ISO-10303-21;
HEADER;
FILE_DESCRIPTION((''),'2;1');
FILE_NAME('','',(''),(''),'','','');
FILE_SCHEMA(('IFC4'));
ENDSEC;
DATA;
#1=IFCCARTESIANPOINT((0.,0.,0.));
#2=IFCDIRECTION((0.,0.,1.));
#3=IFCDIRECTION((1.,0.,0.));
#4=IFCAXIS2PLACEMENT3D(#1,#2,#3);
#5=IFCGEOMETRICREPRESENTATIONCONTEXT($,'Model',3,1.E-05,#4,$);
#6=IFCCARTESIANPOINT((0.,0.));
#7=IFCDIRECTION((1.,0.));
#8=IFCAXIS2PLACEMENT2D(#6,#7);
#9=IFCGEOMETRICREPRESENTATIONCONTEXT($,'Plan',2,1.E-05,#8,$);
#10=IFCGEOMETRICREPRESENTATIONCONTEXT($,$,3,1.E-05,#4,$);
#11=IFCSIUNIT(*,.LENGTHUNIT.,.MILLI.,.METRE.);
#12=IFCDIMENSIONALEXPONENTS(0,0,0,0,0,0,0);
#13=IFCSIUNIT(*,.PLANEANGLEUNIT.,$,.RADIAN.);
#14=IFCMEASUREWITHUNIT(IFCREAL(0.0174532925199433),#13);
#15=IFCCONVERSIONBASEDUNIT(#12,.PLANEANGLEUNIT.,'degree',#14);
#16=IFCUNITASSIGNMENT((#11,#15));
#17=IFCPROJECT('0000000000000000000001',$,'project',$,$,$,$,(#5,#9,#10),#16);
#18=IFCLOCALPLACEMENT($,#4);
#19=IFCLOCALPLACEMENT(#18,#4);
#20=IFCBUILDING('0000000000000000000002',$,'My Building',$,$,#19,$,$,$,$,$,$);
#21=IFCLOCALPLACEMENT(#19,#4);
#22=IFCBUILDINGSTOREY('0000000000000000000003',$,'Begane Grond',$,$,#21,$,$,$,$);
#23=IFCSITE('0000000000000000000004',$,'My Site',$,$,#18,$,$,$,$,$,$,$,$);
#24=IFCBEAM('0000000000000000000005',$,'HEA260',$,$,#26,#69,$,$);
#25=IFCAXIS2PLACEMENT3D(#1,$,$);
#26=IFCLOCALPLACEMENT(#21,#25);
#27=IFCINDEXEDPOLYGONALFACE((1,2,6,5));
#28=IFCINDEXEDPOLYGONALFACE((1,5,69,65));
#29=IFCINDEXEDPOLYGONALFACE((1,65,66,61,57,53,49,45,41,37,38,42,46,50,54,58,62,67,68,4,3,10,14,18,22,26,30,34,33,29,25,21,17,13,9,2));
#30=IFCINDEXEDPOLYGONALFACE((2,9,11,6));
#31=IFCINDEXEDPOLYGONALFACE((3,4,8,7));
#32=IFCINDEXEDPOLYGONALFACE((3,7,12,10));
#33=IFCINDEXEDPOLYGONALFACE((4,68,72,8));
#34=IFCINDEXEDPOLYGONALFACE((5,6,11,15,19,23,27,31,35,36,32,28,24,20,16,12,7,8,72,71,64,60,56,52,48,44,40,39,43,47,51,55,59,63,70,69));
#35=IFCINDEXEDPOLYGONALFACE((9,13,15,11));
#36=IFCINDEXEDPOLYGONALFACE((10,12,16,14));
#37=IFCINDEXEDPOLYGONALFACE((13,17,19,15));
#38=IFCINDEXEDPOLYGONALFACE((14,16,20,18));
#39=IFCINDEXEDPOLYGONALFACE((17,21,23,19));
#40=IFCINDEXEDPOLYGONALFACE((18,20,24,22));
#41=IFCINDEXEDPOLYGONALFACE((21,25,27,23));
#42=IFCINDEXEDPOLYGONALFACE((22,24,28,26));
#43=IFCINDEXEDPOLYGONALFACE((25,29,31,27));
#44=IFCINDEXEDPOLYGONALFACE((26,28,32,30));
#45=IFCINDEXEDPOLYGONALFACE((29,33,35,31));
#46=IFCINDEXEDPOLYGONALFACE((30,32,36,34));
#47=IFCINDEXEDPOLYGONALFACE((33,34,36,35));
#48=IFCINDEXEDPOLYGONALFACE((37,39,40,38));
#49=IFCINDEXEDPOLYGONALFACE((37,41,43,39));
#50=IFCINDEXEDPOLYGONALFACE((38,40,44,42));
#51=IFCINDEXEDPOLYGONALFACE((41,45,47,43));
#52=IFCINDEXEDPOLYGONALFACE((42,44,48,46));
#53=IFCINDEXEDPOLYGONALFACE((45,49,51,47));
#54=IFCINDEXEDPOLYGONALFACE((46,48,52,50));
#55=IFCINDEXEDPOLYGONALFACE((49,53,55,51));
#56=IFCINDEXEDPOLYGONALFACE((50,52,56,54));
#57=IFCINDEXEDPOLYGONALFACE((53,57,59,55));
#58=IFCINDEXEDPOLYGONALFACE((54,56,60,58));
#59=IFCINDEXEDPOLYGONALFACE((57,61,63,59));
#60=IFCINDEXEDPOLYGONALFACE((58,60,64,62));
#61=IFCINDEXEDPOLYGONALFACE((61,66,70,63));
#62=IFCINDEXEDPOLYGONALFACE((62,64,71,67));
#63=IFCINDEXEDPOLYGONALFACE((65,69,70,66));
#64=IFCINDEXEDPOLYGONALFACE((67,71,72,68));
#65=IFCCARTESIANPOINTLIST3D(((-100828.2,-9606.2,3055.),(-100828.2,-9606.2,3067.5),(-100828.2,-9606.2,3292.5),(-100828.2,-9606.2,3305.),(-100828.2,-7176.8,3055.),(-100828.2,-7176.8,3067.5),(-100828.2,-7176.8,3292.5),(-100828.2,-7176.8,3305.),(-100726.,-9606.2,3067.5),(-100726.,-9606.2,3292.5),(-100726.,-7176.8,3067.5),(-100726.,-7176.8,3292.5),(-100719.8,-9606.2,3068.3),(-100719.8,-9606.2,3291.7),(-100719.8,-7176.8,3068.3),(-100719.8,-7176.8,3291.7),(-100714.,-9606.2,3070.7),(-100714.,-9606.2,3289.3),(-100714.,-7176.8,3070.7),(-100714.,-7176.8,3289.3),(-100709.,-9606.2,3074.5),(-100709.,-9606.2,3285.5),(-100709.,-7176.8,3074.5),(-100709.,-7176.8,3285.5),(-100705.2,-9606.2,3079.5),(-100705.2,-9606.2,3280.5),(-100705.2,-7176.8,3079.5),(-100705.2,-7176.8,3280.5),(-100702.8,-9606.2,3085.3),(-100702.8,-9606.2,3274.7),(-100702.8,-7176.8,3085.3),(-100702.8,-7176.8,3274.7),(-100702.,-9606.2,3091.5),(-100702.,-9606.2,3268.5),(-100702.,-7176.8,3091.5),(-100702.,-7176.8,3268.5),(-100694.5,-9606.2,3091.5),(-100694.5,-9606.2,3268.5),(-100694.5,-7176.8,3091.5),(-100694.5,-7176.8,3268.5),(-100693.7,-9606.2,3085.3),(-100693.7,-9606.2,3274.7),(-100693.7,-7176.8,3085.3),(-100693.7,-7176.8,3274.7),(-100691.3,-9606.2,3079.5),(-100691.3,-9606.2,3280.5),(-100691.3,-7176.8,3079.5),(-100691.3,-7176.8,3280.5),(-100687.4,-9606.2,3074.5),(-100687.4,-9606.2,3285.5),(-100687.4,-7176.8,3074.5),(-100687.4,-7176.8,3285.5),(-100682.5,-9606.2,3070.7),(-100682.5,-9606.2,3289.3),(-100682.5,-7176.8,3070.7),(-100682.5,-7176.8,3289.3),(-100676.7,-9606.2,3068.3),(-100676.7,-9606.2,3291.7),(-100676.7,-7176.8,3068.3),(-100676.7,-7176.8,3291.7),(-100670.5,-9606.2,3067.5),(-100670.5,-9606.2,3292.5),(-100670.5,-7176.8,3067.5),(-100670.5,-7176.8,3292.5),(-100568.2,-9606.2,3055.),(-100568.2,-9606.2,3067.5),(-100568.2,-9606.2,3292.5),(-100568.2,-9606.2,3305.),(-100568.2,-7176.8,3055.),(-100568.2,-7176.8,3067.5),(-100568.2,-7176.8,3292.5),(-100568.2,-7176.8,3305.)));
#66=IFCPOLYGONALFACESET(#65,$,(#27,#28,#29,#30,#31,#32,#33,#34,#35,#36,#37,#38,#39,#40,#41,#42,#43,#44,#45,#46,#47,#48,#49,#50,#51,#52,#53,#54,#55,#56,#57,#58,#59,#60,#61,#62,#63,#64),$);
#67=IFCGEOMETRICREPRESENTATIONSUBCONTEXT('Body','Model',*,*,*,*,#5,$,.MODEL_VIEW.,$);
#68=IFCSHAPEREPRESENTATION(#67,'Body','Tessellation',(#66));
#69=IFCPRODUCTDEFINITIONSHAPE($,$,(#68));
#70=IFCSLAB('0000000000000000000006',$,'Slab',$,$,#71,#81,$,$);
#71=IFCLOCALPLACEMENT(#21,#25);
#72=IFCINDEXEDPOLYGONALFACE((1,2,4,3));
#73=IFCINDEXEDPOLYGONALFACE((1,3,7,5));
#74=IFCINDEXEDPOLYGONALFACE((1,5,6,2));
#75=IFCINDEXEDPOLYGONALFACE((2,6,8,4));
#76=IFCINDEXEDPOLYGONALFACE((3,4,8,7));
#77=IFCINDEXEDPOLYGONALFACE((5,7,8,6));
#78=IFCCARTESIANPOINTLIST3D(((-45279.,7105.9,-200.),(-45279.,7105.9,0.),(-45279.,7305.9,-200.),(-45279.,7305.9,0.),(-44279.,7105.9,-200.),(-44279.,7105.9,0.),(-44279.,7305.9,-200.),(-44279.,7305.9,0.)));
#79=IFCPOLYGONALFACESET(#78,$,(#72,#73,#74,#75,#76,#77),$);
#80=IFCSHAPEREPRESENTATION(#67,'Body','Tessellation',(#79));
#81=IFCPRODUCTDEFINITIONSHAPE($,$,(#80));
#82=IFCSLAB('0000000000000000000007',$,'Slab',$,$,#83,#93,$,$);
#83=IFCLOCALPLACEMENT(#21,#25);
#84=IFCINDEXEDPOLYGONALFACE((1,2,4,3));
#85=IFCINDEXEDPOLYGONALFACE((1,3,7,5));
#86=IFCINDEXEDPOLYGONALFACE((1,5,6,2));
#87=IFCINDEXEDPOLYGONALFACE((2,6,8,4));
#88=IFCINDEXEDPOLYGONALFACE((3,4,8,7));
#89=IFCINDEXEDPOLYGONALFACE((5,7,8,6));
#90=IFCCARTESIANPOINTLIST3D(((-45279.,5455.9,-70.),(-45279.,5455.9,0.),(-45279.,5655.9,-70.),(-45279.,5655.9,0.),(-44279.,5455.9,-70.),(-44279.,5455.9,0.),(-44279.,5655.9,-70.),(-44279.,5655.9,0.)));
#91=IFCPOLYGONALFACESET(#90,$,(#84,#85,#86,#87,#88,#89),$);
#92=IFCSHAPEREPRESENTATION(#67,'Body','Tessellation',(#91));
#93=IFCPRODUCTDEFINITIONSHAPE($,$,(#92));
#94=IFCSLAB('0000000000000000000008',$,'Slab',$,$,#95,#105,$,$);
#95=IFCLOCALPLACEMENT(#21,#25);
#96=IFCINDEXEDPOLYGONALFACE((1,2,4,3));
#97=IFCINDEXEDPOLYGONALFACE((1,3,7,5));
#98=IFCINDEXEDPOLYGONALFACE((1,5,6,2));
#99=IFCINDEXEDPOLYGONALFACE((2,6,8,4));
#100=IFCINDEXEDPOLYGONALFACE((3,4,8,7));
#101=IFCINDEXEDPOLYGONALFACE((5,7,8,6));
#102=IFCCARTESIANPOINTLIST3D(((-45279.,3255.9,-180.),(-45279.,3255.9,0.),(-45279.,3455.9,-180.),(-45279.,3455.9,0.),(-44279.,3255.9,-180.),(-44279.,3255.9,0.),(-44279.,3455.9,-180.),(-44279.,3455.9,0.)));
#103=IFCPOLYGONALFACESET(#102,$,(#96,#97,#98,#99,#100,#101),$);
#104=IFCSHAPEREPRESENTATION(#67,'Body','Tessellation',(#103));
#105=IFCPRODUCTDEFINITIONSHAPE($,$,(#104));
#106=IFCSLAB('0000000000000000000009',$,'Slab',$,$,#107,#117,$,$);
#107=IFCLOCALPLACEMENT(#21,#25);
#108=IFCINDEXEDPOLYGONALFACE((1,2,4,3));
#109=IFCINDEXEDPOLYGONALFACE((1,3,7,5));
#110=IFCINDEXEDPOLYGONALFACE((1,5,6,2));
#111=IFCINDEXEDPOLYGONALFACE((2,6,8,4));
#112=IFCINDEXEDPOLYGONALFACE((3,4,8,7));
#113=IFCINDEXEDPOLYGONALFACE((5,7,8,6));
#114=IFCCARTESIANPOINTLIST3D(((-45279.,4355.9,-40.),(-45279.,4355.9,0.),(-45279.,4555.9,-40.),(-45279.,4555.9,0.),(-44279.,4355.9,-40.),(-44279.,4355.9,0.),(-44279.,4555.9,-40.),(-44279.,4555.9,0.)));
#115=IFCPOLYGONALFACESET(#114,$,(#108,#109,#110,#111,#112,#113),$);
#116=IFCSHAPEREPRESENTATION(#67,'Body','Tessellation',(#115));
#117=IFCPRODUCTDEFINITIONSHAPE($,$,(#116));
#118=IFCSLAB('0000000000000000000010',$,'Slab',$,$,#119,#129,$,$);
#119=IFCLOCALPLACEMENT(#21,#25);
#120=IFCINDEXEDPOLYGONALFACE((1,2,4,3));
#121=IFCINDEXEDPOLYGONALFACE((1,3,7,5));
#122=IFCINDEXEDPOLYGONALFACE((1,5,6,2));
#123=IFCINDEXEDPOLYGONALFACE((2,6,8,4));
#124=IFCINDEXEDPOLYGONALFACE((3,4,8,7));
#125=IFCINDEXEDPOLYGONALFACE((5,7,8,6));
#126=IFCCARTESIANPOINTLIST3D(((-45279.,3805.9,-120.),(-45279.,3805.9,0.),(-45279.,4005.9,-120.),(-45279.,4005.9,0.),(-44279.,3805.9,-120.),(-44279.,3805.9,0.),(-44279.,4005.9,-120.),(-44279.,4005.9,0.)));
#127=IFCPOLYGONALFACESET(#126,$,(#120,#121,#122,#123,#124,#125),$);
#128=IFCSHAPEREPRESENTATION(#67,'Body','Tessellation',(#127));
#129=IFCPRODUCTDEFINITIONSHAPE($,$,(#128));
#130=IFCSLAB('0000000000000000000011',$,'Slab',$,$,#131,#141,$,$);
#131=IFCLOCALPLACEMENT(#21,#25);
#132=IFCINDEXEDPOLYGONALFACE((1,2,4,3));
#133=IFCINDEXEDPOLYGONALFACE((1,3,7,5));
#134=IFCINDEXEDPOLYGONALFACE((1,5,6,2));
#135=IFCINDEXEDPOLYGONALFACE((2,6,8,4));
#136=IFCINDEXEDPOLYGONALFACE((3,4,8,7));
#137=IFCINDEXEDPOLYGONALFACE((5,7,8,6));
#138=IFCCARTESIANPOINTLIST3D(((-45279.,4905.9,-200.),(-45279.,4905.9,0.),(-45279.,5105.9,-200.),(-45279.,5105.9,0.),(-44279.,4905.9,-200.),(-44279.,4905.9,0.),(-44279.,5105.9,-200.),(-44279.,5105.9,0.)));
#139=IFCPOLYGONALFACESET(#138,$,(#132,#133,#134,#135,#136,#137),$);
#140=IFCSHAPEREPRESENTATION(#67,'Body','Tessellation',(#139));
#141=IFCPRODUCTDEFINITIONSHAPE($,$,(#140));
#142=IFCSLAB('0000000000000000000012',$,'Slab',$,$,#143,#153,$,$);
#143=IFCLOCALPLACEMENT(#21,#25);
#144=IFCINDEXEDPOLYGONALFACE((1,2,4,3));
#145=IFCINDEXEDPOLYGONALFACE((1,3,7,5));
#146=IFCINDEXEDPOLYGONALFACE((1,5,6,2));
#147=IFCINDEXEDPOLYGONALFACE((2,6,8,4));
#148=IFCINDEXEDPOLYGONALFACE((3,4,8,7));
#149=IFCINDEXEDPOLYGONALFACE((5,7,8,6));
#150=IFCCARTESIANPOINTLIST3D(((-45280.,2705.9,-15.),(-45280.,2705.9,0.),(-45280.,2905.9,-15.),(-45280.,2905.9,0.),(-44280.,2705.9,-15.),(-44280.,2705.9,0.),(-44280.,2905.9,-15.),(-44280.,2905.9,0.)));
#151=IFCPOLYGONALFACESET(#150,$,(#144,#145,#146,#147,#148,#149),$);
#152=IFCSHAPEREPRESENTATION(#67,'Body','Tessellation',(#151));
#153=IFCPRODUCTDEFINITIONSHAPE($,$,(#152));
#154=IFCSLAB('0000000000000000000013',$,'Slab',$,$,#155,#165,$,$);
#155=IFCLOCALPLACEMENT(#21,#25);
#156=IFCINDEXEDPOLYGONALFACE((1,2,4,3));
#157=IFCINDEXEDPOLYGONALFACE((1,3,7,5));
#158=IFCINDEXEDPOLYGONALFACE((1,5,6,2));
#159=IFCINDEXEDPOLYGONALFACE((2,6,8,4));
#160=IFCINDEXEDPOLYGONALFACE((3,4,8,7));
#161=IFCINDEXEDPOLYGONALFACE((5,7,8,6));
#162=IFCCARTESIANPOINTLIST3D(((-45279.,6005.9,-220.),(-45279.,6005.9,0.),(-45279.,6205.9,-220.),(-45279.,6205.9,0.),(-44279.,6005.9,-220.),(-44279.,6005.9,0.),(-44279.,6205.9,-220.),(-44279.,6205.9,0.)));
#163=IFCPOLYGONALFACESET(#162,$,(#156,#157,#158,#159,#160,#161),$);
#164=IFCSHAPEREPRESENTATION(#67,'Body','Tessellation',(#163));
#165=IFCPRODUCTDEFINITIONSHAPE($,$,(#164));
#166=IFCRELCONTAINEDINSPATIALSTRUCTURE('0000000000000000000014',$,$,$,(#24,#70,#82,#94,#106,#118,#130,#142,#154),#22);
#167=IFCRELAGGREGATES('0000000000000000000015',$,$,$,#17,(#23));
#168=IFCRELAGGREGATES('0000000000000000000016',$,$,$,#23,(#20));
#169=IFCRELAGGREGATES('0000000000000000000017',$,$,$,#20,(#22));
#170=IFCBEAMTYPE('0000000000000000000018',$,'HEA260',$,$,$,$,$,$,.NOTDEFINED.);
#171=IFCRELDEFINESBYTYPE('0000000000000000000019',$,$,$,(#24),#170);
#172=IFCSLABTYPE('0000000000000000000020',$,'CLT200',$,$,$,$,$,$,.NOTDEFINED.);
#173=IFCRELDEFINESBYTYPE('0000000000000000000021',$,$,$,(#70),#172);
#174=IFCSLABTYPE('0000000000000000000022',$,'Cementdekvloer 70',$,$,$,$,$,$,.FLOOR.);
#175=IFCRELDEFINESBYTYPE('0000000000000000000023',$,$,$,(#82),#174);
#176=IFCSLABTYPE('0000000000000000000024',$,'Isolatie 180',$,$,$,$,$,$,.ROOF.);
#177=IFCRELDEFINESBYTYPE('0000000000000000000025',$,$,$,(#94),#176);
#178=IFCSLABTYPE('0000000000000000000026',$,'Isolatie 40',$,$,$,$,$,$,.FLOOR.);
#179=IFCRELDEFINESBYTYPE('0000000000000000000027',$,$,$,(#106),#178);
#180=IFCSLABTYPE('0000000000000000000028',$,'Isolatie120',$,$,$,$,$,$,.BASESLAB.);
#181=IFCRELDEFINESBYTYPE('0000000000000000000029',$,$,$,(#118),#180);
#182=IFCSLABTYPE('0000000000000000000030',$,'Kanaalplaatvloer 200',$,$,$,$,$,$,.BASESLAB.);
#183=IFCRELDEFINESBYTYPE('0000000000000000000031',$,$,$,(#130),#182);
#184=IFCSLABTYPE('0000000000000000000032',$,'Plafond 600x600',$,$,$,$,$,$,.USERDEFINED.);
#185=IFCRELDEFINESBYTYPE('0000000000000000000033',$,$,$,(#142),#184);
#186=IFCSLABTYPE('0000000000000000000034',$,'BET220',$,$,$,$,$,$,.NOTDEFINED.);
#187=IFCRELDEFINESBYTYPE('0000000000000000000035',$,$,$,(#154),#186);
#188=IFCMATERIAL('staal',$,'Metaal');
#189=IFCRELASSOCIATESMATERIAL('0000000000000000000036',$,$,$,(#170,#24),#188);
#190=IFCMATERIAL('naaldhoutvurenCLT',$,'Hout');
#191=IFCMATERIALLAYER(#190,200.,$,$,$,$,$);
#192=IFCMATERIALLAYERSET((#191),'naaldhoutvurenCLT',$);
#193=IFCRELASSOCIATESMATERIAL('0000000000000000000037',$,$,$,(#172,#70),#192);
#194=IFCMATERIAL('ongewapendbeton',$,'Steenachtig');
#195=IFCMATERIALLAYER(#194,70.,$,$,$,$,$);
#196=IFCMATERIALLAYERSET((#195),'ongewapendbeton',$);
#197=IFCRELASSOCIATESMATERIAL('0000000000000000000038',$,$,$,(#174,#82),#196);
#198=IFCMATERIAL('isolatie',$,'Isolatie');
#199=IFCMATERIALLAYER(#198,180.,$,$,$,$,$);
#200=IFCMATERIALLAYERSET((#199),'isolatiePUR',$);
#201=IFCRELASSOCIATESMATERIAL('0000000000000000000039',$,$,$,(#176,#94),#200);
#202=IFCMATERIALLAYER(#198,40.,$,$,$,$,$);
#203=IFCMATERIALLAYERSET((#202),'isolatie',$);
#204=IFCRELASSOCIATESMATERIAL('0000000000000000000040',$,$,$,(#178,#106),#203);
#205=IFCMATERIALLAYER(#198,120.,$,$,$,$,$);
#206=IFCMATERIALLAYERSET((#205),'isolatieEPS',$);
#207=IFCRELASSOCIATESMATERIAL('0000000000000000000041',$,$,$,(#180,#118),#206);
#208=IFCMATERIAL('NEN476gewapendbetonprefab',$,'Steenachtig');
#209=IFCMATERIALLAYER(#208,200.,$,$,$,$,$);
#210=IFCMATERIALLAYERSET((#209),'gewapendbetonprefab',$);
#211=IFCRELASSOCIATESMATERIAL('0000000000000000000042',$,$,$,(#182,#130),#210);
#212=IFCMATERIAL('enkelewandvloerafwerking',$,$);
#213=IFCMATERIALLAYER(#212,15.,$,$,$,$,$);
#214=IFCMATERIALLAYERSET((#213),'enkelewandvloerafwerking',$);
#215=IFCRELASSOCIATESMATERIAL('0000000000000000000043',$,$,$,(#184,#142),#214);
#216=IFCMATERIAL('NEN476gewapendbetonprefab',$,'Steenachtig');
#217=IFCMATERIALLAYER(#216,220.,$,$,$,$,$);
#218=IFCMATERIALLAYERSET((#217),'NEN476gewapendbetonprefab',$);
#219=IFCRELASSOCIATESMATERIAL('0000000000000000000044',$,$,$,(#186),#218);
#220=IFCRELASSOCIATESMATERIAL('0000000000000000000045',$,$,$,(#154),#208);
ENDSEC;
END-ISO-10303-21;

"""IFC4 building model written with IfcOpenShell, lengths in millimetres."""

from ifc_helpers import new_model, entity, si_unit, converted_unit, frame, origin_with_axes, origin_2d_with_axis, place, context, subcontext, project, spatial, line, indexed_curve, i_section, outline, extrude, material, layer, layer_set, layer_usage, material_profile, profile_set, profile_usage, type_object, element, save


model = new_model("IFC4")

# Units and contexts
model_context = context("Model", 3, precision=1e-05, world=origin_with_axes())
plan_context = context("Plan", 2, precision=1e-05, world=origin_2d_with_axis())
context_of_model = context(None, 3, precision=1e-05, world=origin_with_axes())
body_context = subcontext(model_context, "Body", "Model", "MODEL_VIEW")
ifc_project = project(units=[si_unit("LENGTHUNIT", "METRE", prefix="MILLI"), converted_unit("PLANEANGLEUNIT", "degree", entity("IfcReal", 0.0174532925199433), si_unit("PLANEANGLEUNIT", "RADIAN"), dimensions=[0, 0, 0, 0, 0, 0, 0])], contexts=[model_context, plan_context, context_of_model])

# Site, building, storey
site_placement = place(None, frame((0.0, 0.0, 0.0), z_axis=(0.0, 0.0, 1.0), x_axis=(1.0, 0.0, 0.0)))
site = spatial("IfcSite", under=ifc_project, at=site_placement, Name="My Site")
building_placement = place(site_placement, origin_with_axes())
building = spatial("IfcBuilding", under=site, at=building_placement, Name="My Building")
storey_placement = place(building_placement, origin_with_axes())
storey = spatial("IfcBuildingStorey", under=building, at=storey_placement, Name="Begane Grond")

# Beam
ifc_material_1 = material(Name="staal", Category="Metaal")
ifc_material_profile = material_profile(ifc_material_1, i_section(OverallWidth=260.0, OverallDepth=250.0, WebThickness=7.5, FlangeThickness=12.5, FilletRadius=24.0))
ifc_profile_set = profile_set([ifc_material_profile], Name="HEA260")
ifc_profile_usage = profile_usage(ifc_profile_set, cardinal=5)
beam_type = type_object("IfcBeamType", Name="HEA260", PredefinedType="NOTDEFINED", material=ifc_profile_set)
beam_placement = place(storey_placement, frame((-100698.2, -9606.2, 3180.0), z_axis=(0.0, 1.0, 0.0), x_axis=(-1.0, 0.0, 0.0)))
element("IfcBeam", 1, at=beam_placement, inside=storey, type_object=beam_type, material=ifc_profile_usage, Name="HEA260", context=body_context, shape_type="SweptSolid", body=[
    extrude(i_section(OverallWidth=260.0, OverallDepth=250.0, WebThickness=7.5, FlangeThickness=12.5, FilletRadius=24.0), origin_with_axes(), (0.0, 0.0, 1.0), 2429.4),
])

# Slabs
ifc_material_2 = material(Name="naaldhoutvurenCLT", Category="Hout")
ifc_layer_1 = layer(ifc_material_2, 200.0)
ifc_layer_set_1 = layer_set([ifc_layer_1], Name="naaldhoutvurenCLT")
ifc_layer_usage_1 = layer_usage(ifc_layer_set_1, "AXIS3", "POSITIVE", 0.0)
slab_type_1 = type_object("IfcSlabType", Name="CLT200", PredefinedType="NOTDEFINED", material=ifc_layer_set_1)
slab_1_placement = place(storey_placement, frame((-45279.0, 7105.9, -200.0), z_axis=(0.0, 0.0, 1.0), x_axis=(1.0, 0.0, 0.0)))
element("IfcSlab", 2, at=slab_1_placement, inside=storey, type_object=slab_type_1, material=ifc_layer_usage_1, Name="Slab", context=body_context, shape_type="SweptSolid", body=[
    extrude(outline(indexed_curve([(1000.0, 200.0), (1000.0, 0.0), (0.0, 0.0), (0.0, 200.0)], segments=[line(3, 2), line(2, 1), line(1, 4), line(4, 3)], self_intersect=False)), None, (0.0, 0.0, 1.0), 200.0),
])
ifc_material_3 = material(Name="ongewapendbeton", Category="Steenachtig")
ifc_layer_2 = layer(ifc_material_3, 70.0)
ifc_layer_set_2 = layer_set([ifc_layer_2], Name="ongewapendbeton")
ifc_layer_usage_2 = layer_usage(ifc_layer_set_2, "AXIS3", "POSITIVE", 0.0)
slab_type_2 = type_object("IfcSlabType", Name="Cementdekvloer 70", PredefinedType="FLOOR", material=ifc_layer_set_2)
slab_2_placement = place(storey_placement, frame((-45279.0, 5455.9, -70.0), z_axis=(0.0, 0.0, 1.0), x_axis=(1.0, 0.0, 0.0)))
element("IfcSlab", 3, at=slab_2_placement, inside=storey, type_object=slab_type_2, material=ifc_layer_usage_2, Name="Slab", context=body_context, shape_type="SweptSolid", body=[
    extrude(outline(indexed_curve([(1000.0, 200.0), (1000.0, 0.0), (0.0, 0.0), (0.0, 200.0)], segments=[line(4, 1), line(1, 2), line(2, 3), line(3, 4)], self_intersect=False)), None, (0.0, 0.0, 1.0), 70.0),
])
ifc_material_4 = material(Name="isolatie", Category="Isolatie")
ifc_layer_3 = layer(ifc_material_4, 180.0)
ifc_layer_set_3 = layer_set([ifc_layer_3], Name="isolatiePUR")
ifc_layer_usage_3 = layer_usage(ifc_layer_set_3, "AXIS3", "POSITIVE", 0.0)
slab_type_3 = type_object("IfcSlabType", Name="Isolatie 180", PredefinedType="ROOF", material=ifc_layer_set_3)
slab_3_placement = place(storey_placement, frame((-45279.0, 3255.9, -180.0), z_axis=(0.0, 0.0, 1.0), x_axis=(1.0, 0.0, 0.0)))
element("IfcSlab", 4, at=slab_3_placement, inside=storey, type_object=slab_type_3, material=ifc_layer_usage_3, Name="Slab", context=body_context, shape_type="SweptSolid", body=[
    extrude(outline(indexed_curve([(1000.0, 200.0), (1000.0, 0.0), (0.0, 0.0), (0.0, 200.0)], segments=[line(4, 1), line(1, 2), line(2, 3), line(3, 4)], self_intersect=False)), None, (0.0, 0.0, 1.0), 180.0),
])
ifc_layer_4 = layer(ifc_material_4, 40.0)
ifc_layer_set_4 = layer_set([ifc_layer_4], Name="isolatie")
ifc_layer_usage_4 = layer_usage(ifc_layer_set_4, "AXIS3", "POSITIVE", 0.0)
slab_type_4 = type_object("IfcSlabType", Name="Isolatie 40", PredefinedType="FLOOR", material=ifc_layer_set_4)
slab_4_placement = place(storey_placement, frame((-45279.0, 4355.9, -40.0), z_axis=(0.0, 0.0, 1.0), x_axis=(1.0, 0.0, 0.0)))
element("IfcSlab", 5, at=slab_4_placement, inside=storey, type_object=slab_type_4, material=ifc_layer_usage_4, Name="Slab", context=body_context, shape_type="SweptSolid", body=[
    extrude(outline(indexed_curve([(1000.0, 200.0), (1000.0, 0.0), (0.0, 0.0), (0.0, 200.0)], segments=[line(3, 2), line(2, 1), line(1, 4), line(4, 3)], self_intersect=False)), None, (0.0, 0.0, 1.0), 40.0),
])
ifc_layer_5 = layer(ifc_material_4, 120.0)
ifc_layer_set_5 = layer_set([ifc_layer_5], Name="isolatieEPS")
ifc_layer_usage_5 = layer_usage(ifc_layer_set_5, "AXIS3", "POSITIVE", 0.0)
slab_type_5 = type_object("IfcSlabType", Name="Isolatie120", PredefinedType="BASESLAB", material=ifc_layer_set_5)
slab_5_placement = place(storey_placement, frame((-45279.0, 3805.9, -120.0), z_axis=(0.0, 0.0, 1.0), x_axis=(1.0, 0.0, 0.0)))
element("IfcSlab", 6, at=slab_5_placement, inside=storey, type_object=slab_type_5, material=ifc_layer_usage_5, Name="Slab", context=body_context, shape_type="SweptSolid", body=[
    extrude(outline(indexed_curve([(1000.0, 200.0), (1000.0, 0.0), (0.0, 0.0), (0.0, 200.0)], segments=[line(3, 2), line(2, 1), line(1, 4), line(4, 3)], self_intersect=False)), None, (0.0, 0.0, 1.0), 120.0),
])
ifc_material_5 = material(Name="NEN476gewapendbetonprefab", Category="Steenachtig")
ifc_layer_6 = layer(ifc_material_5, 200.0)
ifc_layer_set_6 = layer_set([ifc_layer_6], Name="gewapendbetonprefab")
ifc_layer_usage_6 = layer_usage(ifc_layer_set_6, "AXIS3", "POSITIVE", 0.0)
slab_type_6 = type_object("IfcSlabType", Name="Kanaalplaatvloer 200", PredefinedType="BASESLAB", material=ifc_layer_set_6)
slab_6_placement = place(storey_placement, frame((-45279.0, 4905.9, -200.0), z_axis=(0.0, 0.0, 1.0), x_axis=(1.0, 0.0, 0.0)))
element("IfcSlab", 7, at=slab_6_placement, inside=storey, type_object=slab_type_6, material=ifc_layer_usage_6, Name="Slab", context=body_context, shape_type="SweptSolid", body=[
    extrude(outline(indexed_curve([(1000.0, 200.0), (1000.0, 0.0), (0.0, 0.0), (0.0, 200.0)], segments=[line(4, 1), line(1, 2), line(2, 3), line(3, 4)], self_intersect=False)), None, (0.0, 0.0, 1.0), 200.0),
])
ifc_material_6 = material(Name="enkelewandvloerafwerking")
ifc_layer_7 = layer(ifc_material_6, 15.0)
ifc_layer_set_7 = layer_set([ifc_layer_7], Name="enkelewandvloerafwerking")
ifc_layer_usage_7 = layer_usage(ifc_layer_set_7, "AXIS3", "POSITIVE", 0.0)
slab_type_7 = type_object("IfcSlabType", Name="Plafond 600x600", PredefinedType="USERDEFINED", material=ifc_layer_set_7)
slab_7_placement = place(storey_placement, frame((-45280.0, 2705.9, -15.0), z_axis=(0.0, 0.0, 1.0), x_axis=(1.0, 0.0, 0.0)))
element("IfcSlab", 8, at=slab_7_placement, inside=storey, type_object=slab_type_7, material=ifc_layer_usage_7, Name="Slab", context=body_context, shape_type="SweptSolid", body=[
    extrude(outline(indexed_curve([(1000.0, 200.0), (1000.0, 0.0), (0.0, 0.0), (0.0, 200.0)], segments=[line(4, 1), line(1, 2), line(2, 3), line(3, 4)], self_intersect=False)), None, (0.0, 0.0, 1.0), 15.0),
])
ifc_material_7 = material(Name="NEN476gewapendbetonprefab", Category="Steenachtig")
ifc_layer_8 = layer(ifc_material_7, 220.0)
ifc_layer_set_8 = layer_set([ifc_layer_8], Name="NEN476gewapendbetonprefab")
slab_type_8 = type_object("IfcSlabType", Name="BET220", PredefinedType="NOTDEFINED", material=ifc_layer_set_8)
slab_8_placement = place(storey_placement, frame((-45279.0, 6005.9, -220.0), z_axis=(0.0, 0.0, 1.0), x_axis=(1.0, 0.0, 0.0)))
element("IfcSlab", 9, at=slab_8_placement, inside=storey, type_object=slab_type_8, material=ifc_material_5, Name="Slab", context=body_context, shape_type="SweptSolid", body=[
    extrude(outline(indexed_curve([(1000.0, 200.0), (1000.0, 0.0), (0.0, 0.0), (0.0, 200.0)], segments=[line(4, 1), line(1, 2), line(2, 3), line(3, 4)], self_intersect=False)), None, (0.0, 0.0, 1.0), 220.0),
])

save(model, "model.ifc")
